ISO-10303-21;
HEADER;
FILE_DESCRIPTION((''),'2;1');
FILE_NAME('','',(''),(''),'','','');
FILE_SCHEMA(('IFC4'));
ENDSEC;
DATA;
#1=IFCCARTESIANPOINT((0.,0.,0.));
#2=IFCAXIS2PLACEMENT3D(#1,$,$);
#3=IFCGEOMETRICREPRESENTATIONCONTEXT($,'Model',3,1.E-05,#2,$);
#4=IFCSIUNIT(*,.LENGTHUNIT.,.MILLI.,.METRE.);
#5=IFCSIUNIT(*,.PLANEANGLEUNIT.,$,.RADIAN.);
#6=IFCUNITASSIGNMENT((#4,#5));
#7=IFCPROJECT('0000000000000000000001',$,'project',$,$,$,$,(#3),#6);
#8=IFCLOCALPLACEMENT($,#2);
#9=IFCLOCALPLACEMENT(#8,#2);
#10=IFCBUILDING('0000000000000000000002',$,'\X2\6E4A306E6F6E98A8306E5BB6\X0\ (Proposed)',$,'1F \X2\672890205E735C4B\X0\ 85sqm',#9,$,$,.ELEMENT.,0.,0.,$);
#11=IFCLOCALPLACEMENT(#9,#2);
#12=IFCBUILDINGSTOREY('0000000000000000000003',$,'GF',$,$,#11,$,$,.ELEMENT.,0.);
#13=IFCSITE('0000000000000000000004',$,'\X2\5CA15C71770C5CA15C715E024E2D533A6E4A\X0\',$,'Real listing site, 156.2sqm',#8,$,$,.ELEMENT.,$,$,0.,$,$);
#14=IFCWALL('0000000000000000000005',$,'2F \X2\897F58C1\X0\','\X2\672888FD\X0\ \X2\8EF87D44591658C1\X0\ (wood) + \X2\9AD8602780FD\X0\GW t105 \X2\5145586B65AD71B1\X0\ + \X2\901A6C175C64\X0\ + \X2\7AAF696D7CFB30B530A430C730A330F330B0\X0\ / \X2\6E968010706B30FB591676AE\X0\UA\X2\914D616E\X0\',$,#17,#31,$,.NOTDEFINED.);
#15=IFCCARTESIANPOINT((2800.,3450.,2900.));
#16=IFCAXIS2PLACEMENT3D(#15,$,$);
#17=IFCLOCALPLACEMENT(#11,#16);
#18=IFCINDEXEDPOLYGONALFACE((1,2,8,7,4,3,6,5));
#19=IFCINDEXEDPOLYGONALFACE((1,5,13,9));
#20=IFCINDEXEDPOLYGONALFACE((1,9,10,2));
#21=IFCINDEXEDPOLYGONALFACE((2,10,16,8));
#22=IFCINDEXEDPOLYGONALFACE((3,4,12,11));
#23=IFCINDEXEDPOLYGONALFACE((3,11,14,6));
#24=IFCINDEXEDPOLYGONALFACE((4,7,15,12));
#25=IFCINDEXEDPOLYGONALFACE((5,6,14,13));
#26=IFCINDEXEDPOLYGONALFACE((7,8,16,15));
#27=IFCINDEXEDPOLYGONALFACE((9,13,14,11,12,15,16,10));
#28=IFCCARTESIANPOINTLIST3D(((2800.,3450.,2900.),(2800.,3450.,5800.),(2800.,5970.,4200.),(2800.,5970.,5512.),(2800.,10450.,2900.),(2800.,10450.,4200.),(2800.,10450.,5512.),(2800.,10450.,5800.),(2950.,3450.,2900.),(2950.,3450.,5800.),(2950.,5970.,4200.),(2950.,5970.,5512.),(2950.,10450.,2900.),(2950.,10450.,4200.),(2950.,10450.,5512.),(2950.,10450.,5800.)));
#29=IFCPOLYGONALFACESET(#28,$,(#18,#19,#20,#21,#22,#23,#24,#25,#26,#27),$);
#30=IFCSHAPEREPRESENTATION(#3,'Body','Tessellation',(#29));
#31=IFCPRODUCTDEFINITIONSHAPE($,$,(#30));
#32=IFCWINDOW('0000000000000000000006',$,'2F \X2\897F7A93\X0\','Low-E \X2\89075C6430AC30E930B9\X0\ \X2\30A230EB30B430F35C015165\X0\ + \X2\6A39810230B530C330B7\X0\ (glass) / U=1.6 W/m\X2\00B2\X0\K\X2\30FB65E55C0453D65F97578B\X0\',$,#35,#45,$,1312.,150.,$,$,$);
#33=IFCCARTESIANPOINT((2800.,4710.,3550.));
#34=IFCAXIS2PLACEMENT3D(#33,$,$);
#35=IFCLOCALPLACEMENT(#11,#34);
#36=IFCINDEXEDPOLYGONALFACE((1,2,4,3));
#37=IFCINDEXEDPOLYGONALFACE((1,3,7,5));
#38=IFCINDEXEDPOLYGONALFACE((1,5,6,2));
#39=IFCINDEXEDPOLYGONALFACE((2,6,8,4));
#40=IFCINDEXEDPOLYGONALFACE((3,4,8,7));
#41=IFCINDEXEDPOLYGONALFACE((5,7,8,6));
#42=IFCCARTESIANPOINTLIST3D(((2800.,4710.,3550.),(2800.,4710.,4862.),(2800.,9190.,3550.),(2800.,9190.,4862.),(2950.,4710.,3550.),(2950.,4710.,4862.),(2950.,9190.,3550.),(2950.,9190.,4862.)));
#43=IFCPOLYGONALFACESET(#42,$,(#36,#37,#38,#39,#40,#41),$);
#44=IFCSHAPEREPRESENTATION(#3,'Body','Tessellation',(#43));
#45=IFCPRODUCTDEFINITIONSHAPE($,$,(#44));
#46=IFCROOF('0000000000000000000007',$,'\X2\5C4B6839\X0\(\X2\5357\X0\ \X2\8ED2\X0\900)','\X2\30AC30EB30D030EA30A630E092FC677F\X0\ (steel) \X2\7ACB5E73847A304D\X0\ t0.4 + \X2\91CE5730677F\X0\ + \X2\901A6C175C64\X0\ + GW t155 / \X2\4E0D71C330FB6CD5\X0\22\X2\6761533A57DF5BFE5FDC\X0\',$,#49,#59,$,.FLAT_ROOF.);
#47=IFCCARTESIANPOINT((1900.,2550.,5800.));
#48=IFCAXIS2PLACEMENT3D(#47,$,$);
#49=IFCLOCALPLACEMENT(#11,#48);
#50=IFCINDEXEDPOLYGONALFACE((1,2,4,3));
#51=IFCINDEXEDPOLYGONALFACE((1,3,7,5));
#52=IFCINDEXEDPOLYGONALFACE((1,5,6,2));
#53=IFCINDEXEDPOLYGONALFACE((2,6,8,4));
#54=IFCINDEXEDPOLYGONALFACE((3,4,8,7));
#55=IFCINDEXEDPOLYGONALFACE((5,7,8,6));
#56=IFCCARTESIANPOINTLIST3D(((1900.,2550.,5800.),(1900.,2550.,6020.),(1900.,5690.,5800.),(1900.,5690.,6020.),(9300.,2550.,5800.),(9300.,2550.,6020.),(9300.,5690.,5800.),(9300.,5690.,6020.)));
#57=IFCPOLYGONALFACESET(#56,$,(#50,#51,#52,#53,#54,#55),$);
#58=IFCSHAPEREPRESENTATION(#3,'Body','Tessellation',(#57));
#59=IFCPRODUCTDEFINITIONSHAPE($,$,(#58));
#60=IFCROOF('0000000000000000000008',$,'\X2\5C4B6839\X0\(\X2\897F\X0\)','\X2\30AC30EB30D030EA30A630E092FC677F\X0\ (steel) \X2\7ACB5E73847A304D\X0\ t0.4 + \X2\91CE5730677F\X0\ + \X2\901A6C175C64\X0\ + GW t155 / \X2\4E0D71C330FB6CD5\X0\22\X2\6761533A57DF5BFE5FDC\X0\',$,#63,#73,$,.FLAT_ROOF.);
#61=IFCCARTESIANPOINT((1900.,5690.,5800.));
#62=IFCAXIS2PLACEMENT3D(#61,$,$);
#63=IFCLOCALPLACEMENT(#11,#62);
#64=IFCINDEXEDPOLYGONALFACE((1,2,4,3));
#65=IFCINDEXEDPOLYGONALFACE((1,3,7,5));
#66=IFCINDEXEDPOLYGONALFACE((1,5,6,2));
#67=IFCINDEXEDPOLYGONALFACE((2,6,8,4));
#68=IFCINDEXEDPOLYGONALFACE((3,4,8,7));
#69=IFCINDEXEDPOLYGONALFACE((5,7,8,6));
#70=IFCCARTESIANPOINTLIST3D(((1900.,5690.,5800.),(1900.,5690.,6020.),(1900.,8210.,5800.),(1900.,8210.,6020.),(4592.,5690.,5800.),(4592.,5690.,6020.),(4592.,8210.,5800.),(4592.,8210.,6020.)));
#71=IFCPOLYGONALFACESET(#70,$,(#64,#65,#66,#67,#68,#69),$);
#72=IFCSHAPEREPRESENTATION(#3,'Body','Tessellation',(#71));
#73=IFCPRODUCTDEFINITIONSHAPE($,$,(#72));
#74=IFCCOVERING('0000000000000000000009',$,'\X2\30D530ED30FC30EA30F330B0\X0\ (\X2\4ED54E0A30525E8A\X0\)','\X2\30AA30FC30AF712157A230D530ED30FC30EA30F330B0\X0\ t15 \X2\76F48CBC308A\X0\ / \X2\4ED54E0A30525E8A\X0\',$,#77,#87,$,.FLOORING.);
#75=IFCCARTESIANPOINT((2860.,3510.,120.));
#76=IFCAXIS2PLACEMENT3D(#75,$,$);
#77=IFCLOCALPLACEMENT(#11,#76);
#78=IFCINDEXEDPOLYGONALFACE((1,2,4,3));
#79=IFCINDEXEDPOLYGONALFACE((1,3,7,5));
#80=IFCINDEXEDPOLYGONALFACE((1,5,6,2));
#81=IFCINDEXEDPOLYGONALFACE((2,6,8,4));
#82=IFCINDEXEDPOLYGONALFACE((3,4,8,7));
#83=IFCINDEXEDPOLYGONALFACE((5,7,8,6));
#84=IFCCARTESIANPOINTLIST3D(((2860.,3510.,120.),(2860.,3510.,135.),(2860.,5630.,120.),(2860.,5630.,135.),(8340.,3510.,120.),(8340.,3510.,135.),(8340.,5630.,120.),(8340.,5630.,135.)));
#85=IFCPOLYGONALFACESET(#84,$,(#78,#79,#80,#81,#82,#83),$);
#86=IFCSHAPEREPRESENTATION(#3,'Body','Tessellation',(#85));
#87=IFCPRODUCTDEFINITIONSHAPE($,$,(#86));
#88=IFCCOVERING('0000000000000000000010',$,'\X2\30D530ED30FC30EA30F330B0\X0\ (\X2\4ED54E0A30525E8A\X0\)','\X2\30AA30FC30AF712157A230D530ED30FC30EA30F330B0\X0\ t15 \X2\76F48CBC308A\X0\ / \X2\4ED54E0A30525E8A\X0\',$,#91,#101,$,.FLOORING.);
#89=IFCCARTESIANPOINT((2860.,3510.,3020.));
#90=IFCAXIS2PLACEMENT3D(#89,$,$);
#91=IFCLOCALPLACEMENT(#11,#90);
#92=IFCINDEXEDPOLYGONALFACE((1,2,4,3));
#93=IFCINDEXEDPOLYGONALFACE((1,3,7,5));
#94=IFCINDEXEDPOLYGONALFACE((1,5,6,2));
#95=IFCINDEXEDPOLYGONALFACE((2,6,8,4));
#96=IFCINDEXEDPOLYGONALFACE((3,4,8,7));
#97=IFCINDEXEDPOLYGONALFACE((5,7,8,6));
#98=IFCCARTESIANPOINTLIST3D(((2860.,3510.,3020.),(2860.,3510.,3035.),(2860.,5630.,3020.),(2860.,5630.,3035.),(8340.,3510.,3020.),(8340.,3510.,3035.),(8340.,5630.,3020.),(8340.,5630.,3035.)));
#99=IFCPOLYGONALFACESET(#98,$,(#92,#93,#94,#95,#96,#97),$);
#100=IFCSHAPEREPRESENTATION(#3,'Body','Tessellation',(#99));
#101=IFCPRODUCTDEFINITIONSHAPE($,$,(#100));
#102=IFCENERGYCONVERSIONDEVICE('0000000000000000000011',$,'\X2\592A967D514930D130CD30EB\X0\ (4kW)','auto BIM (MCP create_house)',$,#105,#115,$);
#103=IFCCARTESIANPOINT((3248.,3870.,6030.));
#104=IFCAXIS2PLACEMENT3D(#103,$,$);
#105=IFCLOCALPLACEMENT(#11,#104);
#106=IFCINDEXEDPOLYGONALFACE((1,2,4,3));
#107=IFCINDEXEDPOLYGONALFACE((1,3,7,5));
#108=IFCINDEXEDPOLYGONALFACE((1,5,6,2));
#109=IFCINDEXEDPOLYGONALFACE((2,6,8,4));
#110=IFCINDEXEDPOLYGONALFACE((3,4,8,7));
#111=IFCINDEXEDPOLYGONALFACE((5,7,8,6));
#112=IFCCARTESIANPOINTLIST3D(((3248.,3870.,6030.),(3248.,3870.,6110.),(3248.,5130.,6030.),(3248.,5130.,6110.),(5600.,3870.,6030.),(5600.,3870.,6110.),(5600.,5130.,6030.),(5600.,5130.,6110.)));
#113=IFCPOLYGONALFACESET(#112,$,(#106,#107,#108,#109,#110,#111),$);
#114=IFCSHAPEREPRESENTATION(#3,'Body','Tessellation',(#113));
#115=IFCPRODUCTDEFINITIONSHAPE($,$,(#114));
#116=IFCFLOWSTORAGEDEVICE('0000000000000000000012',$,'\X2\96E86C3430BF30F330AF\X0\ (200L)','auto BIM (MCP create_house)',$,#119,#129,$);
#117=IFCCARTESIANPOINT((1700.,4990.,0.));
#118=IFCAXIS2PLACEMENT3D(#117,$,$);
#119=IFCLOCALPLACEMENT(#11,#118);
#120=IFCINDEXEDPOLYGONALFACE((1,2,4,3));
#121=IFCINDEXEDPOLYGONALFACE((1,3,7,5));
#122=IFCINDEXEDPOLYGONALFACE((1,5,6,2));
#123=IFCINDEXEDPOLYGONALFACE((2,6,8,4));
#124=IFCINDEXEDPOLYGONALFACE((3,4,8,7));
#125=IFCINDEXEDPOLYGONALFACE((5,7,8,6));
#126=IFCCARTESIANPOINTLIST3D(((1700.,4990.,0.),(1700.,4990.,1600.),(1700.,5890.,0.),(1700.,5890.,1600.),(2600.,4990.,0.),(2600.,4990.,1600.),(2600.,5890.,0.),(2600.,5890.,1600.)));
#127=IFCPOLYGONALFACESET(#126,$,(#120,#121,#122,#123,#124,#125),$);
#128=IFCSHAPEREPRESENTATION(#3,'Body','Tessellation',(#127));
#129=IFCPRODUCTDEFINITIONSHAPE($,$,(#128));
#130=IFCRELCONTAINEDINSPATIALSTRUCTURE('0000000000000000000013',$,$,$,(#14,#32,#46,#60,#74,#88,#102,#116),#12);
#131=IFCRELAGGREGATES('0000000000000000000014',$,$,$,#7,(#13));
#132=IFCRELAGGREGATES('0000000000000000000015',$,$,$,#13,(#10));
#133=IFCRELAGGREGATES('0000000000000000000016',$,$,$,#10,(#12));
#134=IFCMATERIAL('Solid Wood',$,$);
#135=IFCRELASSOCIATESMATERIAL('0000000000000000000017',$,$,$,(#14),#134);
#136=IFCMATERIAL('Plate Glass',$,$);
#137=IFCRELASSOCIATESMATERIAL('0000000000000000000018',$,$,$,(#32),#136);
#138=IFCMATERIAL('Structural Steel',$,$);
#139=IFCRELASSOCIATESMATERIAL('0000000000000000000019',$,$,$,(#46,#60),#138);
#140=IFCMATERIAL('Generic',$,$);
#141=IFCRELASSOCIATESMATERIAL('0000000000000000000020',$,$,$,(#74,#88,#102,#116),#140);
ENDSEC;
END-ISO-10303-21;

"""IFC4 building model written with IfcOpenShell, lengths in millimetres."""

from ifc_helpers import new_model, si_unit, frame, frame_2d, origin, place, context, project, spatial, rectangle, extrude, material, element, fill, save


model = new_model("IFC4")

# Units and contexts
model_context = context("Model", 3, precision=1e-05, world=origin())
ifc_project = project(units=[si_unit("LENGTHUNIT", "METRE", prefix="MILLI"), si_unit("PLANEANGLEUNIT", "RADIAN")], contexts=[model_context])

# Site, building, storey
site_placement = place(None, origin())
site = spatial("IfcSite", under=ifc_project, at=site_placement, Name="岡山県岡山市中区湊", ObjectType="Real listing site, 156.2sqm", CompositionType="ELEMENT", RefElevation=0.0)
building_placement = place(site_placement, origin())
building = spatial("IfcBuilding", under=site, at=building_placement, Name="湊の潮風の家 (Proposed)", ObjectType="1F 木造平屋 85sqm", CompositionType="ELEMENT", ElevationOfRefHeight=0.0, ElevationOfTerrain=0.0)
storey_placement = place(building_placement, origin())
storey = spatial("IfcBuildingStorey", under=building, at=storey_placement, Name="GF", CompositionType="ELEMENT", Elevation=0.0)

# Shared definitions
ifc_material_1 = material(Name="Solid Wood")
ifc_material_2 = material(Name="Generic")

# Shared definitions
ifc_material_3 = material(Name="Plate Glass")

# Wall, opening, window
wall_1_placement = place(storey_placement, frame((2800.0, 3450.0, 2900.0)))
wall_1 = element("IfcWall", 1, at=wall_1_placement, inside=storey, material=ifc_material_1, Name="2F 西壁", Description="木製 軸組外壁 (wood) + 高性能GW t105 充填断熱 + 通気層 + 窯業系サイディング / 準耐火・外皮UA配慮", PredefinedType="NOTDEFINED", context=model_context, shape_type="SweptSolid", body=[
    extrude(rectangle(XDim=150.0, YDim=7000.0, at=frame_2d((75.0, 3500.0))), frame((2800.0, 3450.0, 2900.0)), (0.0, 0.0, 1.0), 2900.0),
])
opening_1_placement = place(storey_placement, frame((2800.0, 4710.0, 3550.0)))
opening_1 = element("IfcOpeningElement", 2, at=opening_1_placement, cuts=wall_1, PredefinedType="NOTDEFINED", context=model_context, shape_type="SweptSolid", body=[
    extrude(rectangle(XDim=150.0, YDim=4480.0, at=frame_2d((75.0, 2240.0))), frame((2800.0, 4710.0, 3550.0)), (0.0, 0.0, 1.0), 1312.0),
])
window_1_placement = place(storey_placement, frame((2800.0, 4710.0, 3550.0)))
window_1 = element("IfcWindow", 3, at=window_1_placement, inside=storey, material=ifc_material_3, Name="2F 西窓", Description="Low-E 複層ガラス アルゴン封入 + 樹脂サッシ (glass) / U=1.6 W/m²K・日射取得型", OverallHeight=1312.0, OverallWidth=150.0, context=model_context, shape_type="SweptSolid", body=[
    extrude(rectangle(XDim=150.0, YDim=4480.0, at=frame_2d((75.0, 2240.0))), frame((2800.0, 4710.0, 3550.0)), (0.0, 0.0, 1.0), 1312.0),
])
fill(opening_1, window_1)

# Roofs
ifc_material_4 = material(Name="Structural Steel")
roof_1_placement = place(storey_placement, frame((1900.0, 2550.0, 5800.0)))
element("IfcRoof", 4, at=roof_1_placement, inside=storey, material=ifc_material_4, Name="屋根(南 軒900)", Description="ガルバリウム鋼板 (steel) 立平葺き t0.4 + 野地板 + 通気層 + GW t155 / 不燃・法22条区域対応", PredefinedType="FLAT_ROOF", context=model_context, shape_type="SweptSolid", body=[
    extrude(rectangle(XDim=7400.0, YDim=3140.0, at=frame_2d((3700.0, 1570.0))), frame((1900.0, 2550.0, 5800.0)), (0.0, 0.0, 1.0), 220.0),
])
roof_2_placement = place(storey_placement, frame((1900.0, 5690.0, 5800.0)))
element("IfcRoof", 5, at=roof_2_placement, inside=storey, material=ifc_material_4, Name="屋根(西)", Description="ガルバリウム鋼板 (steel) 立平葺き t0.4 + 野地板 + 通気層 + GW t155 / 不燃・法22条区域対応", PredefinedType="FLAT_ROOF", context=model_context, shape_type="SweptSolid", body=[
    extrude(rectangle(XDim=2692.0, YDim=2520.0, at=frame_2d((1346.0, 1260.0))), frame((1900.0, 5690.0, 5800.0)), (0.0, 0.0, 1.0), 220.0),
])

# Coverings
covering_1_placement = place(storey_placement, frame((2860.0, 3510.0, 120.0)))
element("IfcCovering", 6, at=covering_1_placement, inside=storey, material=ifc_material_2, Name="フローリング (仕上げ床)", Description="オーク無垢フローリング t15 直貼り / 仕上げ床", PredefinedType="FLOORING", context=model_context, shape_type="SweptSolid", body=[
    extrude(rectangle(XDim=5480.0, YDim=2120.0, at=frame_2d((2740.0, 1060.0))), frame((2860.0, 3510.0, 120.0)), (0.0, 0.0, 1.0), 15.0),
])
covering_2_placement = place(storey_placement, frame((2860.0, 3510.0, 3020.0)))
element("IfcCovering", 7, at=covering_2_placement, inside=storey, material=ifc_material_2, Name="フローリング (仕上げ床)", Description="オーク無垢フローリング t15 直貼り / 仕上げ床", PredefinedType="FLOORING", context=model_context, shape_type="SweptSolid", body=[
    extrude(rectangle(XDim=5480.0, YDim=2120.0, at=frame_2d((2740.0, 1060.0))), frame((2860.0, 3510.0, 3020.0)), (0.0, 0.0, 1.0), 15.0),
])

# Energy conversion device
energy_conversion_device_placement = place(storey_placement, frame((3248.0, 3870.0, 6030.0)))
element("IfcEnergyConversionDevice", 8, at=energy_conversion_device_placement, inside=storey, material=ifc_material_2, Name="太陽光パネル (4kW)", Description="auto BIM (MCP create_house)", context=model_context, shape_type="SweptSolid", body=[
    extrude(rectangle(XDim=2352.0, YDim=1260.0, at=frame_2d((1176.0, 630.0))), frame((3248.0, 3870.0, 6030.0)), (0.0, 0.0, 1.0), 80.0),
])

# Flow storage device
flow_storage_device_placement = place(storey_placement, frame((1700.0, 4990.0, 0.0)))
element("IfcFlowStorageDevice", 9, at=flow_storage_device_placement, inside=storey, material=ifc_material_2, Name="雨水タンク (200L)", Description="auto BIM (MCP create_house)", context=model_context, shape_type="SweptSolid", body=[
    extrude(rectangle(XDim=900.0, YDim=900.0, at=frame_2d((450.0, 450.0))), frame((1700.0, 4990.0, 0.0)), (0.0, 0.0, 1.0), 1600.0),
])

save(model, "model.ifc")
